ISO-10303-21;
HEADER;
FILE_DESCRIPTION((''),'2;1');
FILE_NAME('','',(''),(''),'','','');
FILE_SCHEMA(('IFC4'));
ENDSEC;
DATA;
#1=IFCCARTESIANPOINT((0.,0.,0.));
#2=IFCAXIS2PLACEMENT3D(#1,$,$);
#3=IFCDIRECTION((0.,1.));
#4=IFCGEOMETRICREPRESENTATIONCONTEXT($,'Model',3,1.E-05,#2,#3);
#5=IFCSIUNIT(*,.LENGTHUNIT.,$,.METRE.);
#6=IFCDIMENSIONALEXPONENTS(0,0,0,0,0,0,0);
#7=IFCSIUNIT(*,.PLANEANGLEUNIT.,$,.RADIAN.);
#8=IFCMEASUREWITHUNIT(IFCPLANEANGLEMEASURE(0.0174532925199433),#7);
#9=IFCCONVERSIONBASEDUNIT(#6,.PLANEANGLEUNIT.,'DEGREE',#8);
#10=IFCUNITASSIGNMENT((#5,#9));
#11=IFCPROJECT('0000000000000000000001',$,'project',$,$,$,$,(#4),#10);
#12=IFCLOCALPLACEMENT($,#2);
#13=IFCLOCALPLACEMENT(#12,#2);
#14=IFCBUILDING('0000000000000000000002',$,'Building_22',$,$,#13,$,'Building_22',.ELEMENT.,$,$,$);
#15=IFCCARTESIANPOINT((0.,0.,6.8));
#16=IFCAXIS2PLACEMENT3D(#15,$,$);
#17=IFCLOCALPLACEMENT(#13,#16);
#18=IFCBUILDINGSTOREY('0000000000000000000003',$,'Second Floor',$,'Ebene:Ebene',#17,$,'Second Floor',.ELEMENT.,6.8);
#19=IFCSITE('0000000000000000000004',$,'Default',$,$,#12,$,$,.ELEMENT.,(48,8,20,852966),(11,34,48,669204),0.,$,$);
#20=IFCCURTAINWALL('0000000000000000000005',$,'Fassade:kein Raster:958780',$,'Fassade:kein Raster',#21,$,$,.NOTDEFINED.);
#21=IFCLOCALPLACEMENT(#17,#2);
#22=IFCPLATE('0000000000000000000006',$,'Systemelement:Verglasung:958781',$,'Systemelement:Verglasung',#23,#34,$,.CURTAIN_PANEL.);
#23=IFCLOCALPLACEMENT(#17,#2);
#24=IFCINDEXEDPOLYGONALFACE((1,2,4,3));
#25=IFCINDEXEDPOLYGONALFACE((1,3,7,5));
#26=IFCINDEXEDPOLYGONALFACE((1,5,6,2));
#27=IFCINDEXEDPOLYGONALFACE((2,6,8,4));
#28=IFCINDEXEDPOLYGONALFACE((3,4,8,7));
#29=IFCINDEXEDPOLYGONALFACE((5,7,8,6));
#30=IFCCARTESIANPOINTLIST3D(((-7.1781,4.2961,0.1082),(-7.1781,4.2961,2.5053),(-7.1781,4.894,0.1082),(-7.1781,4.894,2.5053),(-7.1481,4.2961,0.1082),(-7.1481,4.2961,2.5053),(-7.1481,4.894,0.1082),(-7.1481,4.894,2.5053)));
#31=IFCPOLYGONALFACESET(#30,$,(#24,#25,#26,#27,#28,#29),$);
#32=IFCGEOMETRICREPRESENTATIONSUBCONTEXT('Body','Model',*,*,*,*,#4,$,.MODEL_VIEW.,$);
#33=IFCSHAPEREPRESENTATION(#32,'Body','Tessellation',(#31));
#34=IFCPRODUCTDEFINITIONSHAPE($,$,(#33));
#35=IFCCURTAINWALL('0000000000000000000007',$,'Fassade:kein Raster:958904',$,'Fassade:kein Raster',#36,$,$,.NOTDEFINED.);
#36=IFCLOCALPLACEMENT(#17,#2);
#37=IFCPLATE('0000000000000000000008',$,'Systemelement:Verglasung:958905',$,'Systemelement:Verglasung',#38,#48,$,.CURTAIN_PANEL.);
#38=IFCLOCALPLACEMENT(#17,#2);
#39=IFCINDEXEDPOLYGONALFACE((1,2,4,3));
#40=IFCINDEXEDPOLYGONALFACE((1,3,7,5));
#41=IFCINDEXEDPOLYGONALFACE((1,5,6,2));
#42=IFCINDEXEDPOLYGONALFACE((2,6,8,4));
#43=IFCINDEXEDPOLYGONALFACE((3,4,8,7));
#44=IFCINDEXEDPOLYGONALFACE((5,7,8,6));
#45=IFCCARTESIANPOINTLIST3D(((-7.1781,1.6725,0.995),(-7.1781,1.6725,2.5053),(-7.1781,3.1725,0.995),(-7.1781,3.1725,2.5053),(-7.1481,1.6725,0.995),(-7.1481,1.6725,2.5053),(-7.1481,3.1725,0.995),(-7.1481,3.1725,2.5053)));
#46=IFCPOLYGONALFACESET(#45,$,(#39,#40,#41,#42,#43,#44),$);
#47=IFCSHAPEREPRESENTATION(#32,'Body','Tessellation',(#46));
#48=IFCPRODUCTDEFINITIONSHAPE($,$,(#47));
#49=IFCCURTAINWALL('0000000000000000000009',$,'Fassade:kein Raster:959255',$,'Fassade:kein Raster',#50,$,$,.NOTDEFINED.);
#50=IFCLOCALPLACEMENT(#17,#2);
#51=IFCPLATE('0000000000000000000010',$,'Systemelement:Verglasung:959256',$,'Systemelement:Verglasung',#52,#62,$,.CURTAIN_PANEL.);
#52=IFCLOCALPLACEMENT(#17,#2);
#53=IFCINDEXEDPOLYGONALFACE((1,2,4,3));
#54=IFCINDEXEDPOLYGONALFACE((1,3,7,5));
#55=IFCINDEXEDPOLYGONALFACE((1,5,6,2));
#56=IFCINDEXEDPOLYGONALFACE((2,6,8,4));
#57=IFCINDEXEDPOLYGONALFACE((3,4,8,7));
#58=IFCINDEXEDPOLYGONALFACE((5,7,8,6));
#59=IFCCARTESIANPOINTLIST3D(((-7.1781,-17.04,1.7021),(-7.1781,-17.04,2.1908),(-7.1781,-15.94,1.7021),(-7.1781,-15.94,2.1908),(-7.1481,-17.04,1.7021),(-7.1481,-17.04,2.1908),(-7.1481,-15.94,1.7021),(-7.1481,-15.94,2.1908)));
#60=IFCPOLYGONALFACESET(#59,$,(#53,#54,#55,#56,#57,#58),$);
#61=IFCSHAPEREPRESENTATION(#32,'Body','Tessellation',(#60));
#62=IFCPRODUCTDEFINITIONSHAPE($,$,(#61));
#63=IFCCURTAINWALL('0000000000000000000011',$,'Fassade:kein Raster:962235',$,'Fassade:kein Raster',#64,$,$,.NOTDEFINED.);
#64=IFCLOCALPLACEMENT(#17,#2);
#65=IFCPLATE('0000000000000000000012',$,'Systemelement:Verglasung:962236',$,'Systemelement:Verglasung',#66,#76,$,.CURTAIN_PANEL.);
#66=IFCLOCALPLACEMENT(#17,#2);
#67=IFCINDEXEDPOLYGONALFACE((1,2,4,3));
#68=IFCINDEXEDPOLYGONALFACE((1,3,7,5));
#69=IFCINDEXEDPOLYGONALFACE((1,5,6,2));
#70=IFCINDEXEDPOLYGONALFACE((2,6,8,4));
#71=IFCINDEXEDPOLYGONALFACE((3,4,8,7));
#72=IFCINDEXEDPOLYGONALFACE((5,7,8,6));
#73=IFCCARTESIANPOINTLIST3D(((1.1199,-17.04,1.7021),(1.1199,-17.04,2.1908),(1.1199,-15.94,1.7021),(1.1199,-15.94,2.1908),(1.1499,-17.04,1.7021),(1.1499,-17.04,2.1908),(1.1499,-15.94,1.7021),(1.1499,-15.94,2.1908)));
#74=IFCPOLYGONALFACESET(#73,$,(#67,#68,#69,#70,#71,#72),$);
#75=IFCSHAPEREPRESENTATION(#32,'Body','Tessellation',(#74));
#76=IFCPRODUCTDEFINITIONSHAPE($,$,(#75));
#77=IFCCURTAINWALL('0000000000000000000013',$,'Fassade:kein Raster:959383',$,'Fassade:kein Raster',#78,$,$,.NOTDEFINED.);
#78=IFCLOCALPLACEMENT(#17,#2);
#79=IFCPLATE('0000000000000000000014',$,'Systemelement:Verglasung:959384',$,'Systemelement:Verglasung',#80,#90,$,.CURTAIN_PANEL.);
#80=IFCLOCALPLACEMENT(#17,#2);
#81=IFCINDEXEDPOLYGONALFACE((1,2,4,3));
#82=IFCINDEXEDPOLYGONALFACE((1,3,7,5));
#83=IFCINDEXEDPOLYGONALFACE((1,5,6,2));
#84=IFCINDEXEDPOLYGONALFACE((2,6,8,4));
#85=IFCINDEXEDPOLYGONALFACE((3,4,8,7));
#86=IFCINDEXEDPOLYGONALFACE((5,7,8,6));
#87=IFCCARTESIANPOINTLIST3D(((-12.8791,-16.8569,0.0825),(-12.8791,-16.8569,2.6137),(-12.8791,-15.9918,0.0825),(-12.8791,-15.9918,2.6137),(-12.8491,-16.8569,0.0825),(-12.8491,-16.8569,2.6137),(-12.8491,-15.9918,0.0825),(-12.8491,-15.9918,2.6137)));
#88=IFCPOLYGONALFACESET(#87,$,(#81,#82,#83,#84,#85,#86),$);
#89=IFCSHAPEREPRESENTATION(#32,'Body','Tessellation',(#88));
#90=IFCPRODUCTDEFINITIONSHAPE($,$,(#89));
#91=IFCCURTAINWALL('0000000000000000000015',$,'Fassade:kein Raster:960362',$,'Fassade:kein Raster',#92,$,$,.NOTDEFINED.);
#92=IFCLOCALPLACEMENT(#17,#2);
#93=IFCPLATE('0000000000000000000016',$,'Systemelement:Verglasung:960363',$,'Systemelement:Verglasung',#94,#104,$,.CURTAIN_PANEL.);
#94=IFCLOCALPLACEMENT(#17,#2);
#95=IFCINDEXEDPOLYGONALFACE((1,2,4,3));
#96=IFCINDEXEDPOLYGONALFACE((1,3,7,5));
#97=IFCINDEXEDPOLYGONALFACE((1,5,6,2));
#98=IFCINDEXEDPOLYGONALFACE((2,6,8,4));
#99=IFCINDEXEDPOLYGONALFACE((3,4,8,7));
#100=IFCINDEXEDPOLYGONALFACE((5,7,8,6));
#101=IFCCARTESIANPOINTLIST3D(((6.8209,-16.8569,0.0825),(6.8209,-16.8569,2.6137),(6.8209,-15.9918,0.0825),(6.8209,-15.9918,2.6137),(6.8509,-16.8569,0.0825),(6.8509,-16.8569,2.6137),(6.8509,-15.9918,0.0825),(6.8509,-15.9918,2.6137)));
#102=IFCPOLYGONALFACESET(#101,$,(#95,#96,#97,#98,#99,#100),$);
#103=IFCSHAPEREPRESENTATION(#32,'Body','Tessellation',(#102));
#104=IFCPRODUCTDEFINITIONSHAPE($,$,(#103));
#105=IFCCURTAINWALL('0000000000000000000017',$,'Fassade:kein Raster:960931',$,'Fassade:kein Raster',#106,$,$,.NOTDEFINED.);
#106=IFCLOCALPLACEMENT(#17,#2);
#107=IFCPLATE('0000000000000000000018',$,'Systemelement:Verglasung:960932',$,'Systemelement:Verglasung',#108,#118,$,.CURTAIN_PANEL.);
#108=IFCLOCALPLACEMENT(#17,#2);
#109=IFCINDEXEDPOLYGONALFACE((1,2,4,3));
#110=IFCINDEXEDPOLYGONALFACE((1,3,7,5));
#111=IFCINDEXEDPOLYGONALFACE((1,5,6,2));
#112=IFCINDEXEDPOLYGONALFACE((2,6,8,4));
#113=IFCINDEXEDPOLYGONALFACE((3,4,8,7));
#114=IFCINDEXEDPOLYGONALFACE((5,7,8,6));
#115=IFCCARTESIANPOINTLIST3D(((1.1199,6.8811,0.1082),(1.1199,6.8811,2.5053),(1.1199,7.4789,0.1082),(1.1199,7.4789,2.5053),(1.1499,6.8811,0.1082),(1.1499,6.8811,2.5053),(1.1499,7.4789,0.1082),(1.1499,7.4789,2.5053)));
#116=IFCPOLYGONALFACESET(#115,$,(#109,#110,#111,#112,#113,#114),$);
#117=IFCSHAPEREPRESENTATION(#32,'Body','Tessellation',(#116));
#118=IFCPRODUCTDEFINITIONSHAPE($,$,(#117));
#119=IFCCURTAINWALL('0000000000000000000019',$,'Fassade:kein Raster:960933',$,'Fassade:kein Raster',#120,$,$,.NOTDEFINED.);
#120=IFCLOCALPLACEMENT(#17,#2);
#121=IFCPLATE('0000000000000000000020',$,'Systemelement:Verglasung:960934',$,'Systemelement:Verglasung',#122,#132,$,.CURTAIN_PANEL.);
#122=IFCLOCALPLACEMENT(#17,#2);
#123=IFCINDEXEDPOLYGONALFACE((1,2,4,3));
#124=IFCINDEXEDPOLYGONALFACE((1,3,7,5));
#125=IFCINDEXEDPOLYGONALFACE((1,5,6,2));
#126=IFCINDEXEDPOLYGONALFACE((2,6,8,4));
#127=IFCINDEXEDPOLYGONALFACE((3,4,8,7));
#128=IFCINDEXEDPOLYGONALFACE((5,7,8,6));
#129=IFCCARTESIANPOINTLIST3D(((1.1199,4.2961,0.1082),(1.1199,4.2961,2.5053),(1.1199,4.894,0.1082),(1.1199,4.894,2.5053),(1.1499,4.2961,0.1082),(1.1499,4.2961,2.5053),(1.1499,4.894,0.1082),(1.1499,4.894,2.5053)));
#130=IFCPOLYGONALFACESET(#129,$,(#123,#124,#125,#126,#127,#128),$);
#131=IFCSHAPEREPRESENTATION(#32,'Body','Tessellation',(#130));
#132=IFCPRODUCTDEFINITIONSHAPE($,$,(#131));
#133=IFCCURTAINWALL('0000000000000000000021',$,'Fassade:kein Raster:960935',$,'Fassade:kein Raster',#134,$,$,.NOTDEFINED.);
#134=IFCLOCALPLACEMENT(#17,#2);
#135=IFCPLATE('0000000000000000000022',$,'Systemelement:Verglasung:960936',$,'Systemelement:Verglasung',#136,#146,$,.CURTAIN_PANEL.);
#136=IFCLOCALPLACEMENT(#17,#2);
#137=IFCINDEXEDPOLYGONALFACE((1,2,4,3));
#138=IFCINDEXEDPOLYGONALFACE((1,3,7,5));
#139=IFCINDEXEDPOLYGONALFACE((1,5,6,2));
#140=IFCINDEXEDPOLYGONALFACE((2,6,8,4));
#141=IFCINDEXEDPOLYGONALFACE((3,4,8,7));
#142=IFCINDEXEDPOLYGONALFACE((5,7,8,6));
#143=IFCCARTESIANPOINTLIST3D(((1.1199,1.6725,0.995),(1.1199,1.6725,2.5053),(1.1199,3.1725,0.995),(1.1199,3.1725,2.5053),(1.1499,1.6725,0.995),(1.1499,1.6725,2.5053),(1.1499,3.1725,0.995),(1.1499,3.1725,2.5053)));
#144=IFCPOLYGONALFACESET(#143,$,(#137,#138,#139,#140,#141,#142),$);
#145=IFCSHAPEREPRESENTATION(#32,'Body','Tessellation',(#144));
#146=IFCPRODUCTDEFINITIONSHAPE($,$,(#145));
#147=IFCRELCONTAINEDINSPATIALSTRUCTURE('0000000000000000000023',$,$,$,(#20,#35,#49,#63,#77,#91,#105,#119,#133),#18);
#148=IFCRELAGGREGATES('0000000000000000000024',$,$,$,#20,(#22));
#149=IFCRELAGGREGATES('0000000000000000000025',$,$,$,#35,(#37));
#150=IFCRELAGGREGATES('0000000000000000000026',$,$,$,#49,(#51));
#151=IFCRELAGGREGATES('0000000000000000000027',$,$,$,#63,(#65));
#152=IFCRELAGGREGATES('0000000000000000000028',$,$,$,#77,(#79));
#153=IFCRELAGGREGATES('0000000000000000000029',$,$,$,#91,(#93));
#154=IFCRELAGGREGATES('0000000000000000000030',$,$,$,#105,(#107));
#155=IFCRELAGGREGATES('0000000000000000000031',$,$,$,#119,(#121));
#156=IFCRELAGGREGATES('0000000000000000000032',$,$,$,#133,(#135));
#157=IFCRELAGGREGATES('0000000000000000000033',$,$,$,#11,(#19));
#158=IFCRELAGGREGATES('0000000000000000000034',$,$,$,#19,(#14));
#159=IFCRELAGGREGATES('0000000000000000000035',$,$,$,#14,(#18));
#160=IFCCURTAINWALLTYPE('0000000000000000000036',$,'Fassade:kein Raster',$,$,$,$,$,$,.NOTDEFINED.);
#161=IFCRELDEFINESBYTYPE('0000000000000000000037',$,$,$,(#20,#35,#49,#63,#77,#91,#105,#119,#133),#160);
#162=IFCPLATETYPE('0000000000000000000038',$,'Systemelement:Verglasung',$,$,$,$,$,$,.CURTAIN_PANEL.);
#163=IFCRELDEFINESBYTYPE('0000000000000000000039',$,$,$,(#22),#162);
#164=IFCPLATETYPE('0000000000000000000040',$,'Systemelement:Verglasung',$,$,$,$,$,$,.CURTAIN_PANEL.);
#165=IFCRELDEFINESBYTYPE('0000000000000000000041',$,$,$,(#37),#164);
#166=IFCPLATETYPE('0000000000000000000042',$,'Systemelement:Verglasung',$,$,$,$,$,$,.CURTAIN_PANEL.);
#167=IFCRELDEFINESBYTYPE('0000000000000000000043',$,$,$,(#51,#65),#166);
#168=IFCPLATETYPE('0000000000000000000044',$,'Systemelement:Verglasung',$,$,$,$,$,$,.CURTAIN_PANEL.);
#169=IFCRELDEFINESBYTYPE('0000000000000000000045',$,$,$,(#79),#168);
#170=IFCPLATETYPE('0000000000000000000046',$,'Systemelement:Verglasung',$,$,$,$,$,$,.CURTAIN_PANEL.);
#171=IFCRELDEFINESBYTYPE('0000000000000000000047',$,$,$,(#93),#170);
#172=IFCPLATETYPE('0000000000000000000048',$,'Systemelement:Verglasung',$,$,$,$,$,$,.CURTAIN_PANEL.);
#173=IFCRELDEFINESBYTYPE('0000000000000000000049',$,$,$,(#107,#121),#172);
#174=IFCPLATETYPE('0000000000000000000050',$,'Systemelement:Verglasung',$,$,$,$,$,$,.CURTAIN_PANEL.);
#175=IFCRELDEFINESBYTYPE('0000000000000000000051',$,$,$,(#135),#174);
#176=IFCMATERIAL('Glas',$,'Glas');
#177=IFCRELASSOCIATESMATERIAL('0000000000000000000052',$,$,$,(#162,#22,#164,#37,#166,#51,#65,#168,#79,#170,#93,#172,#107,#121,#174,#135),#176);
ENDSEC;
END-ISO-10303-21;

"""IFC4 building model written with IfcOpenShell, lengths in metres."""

from ifc_helpers import new_model, entity, si_unit, converted_unit, direction, frame, origin, place, context, subcontext, project, spatial, indexed_curve, outline, extrude, source, transform, mapped, material, type_object, type_shapes, element, aggregate, save


model = new_model("IFC4")

# Units and contexts
model_context = context("Model", 3, precision=1e-05, world=origin(), true_north=direction((0.0, 1.0)))
body_context = subcontext(model_context, "Body", "Model", "MODEL_VIEW")
ifc_project = project(units=[si_unit("LENGTHUNIT", "METRE"), converted_unit("PLANEANGLEUNIT", "DEGREE", entity("IfcPlaneAngleMeasure", 0.0174532925199433), si_unit("PLANEANGLEUNIT", "RADIAN"), dimensions=[0, 0, 0, 0, 0, 0, 0])], contexts=[model_context])

# Site, building, storey
site_placement = place(None, origin())
site = spatial("IfcSite", under=ifc_project, at=site_placement, Name="Default", CompositionType="ELEMENT", RefLatitude=(48, 8, 20, 852966), RefLongitude=(11, 34, 48, 669204), RefElevation=0.0)
building_placement = place(site_placement, origin())
building = spatial("IfcBuilding", under=site, at=building_placement, Name="Building_22", LongName="Building_22", CompositionType="ELEMENT")
storey_placement = place(building_placement, frame((0.0, 0.0, 6.8)))
storey = spatial("IfcBuildingStorey", under=building, at=storey_placement, Name="Second Floor", ObjectType="Ebene:Ebene", LongName="Second Floor", CompositionType="ELEMENT", Elevation=6.8)

# Curtain walls, plates
curtain_wall_type_1 = type_object("IfcCurtainWallType", Name="Fassade:kein Raster", PredefinedType="NOTDEFINED")
ifc_material_1 = material(Name="Glas", Category="Glas")
plate_type_1 = type_object("IfcPlateType", Name="Systemelement:Verglasung", PredefinedType="CURTAIN_PANEL", material=ifc_material_1)
shared_shape_1 = source(origin(), body_context, "Body", "SweptSolid", [
    extrude(outline(indexed_curve([(-0.015, -0.2989), (0.015, -0.2989), (0.015, 0.2989), (-0.015, 0.2989), (-0.015, -0.2989)], self_intersect=False)), frame((0.0, 0.0, 0.0), z_axis=(0.0, 0.0, 1.0), x_axis=(0.0, 1.0, 0.0)), (0.0, 0.0, 1.0), 2.3972),
])
type_shapes(plate_type_1, [shared_shape_1])
curtain_wall_1_placement = place(storey_placement, frame((0.0, 0.0, -6.8)))
curtain_wall_1 = element("IfcCurtainWall", 1, at=curtain_wall_1_placement, inside=storey, type_object=curtain_wall_type_1, Name="Fassade:kein Raster:958780", ObjectType="Fassade:kein Raster", PredefinedType="NOTDEFINED")
plate_1_placement = place(curtain_wall_1_placement, frame((-7.1631, 4.595, 6.9082), z_axis=(0.0, 0.0, 1.0), x_axis=(0.0, -1.0, 0.0)))
plate_1 = element("IfcPlate", 2, at=plate_1_placement, type_object=plate_type_1, material=ifc_material_1, Name="Systemelement:Verglasung:958781", ObjectType="Systemelement:Verglasung", PredefinedType="CURTAIN_PANEL", context=body_context, shape_type="MappedRepresentation", body=[
    mapped(shared_shape_1, transform((0.0, 0.0, 0.0), scale=1.0)),
])
aggregate(curtain_wall_1, [plate_1])
curtain_wall_2_placement = place(storey_placement, frame((0.0, 0.0, -6.8)))
curtain_wall_2 = element("IfcCurtainWall", 3, at=curtain_wall_2_placement, inside=storey, type_object=curtain_wall_type_1, Name="Fassade:kein Raster:958904", ObjectType="Fassade:kein Raster", PredefinedType="NOTDEFINED")
plate_type_2 = type_object("IfcPlateType", Name="Systemelement:Verglasung", PredefinedType="CURTAIN_PANEL", material=ifc_material_1)
shared_shape_2 = source(origin(), body_context, "Body", "SweptSolid", [
    extrude(outline(indexed_curve([(-0.015, -0.75), (0.015, -0.75), (0.015, 0.75), (-0.015, 0.75), (-0.015, -0.75)], self_intersect=False)), frame((0.0, 0.0, 0.0), z_axis=(0.0, 0.0, 1.0), x_axis=(0.0, 1.0, 0.0)), (0.0, 0.0, 1.0), 1.5104),
])
type_shapes(plate_type_2, [shared_shape_2])
plate_2_placement = place(curtain_wall_2_placement, frame((-7.1631, 2.4225, 7.795), z_axis=(0.0, 0.0, 1.0), x_axis=(0.0, -1.0, 0.0)))
plate_2 = element("IfcPlate", 4, at=plate_2_placement, type_object=plate_type_2, material=ifc_material_1, Name="Systemelement:Verglasung:958905", ObjectType="Systemelement:Verglasung", PredefinedType="CURTAIN_PANEL", context=body_context, shape_type="MappedRepresentation", body=[
    mapped(shared_shape_2, transform((0.0, 0.0, 0.0), scale=1.0)),
])
aggregate(curtain_wall_2, [plate_2])
curtain_wall_3_placement = place(storey_placement, frame((0.0, 0.0, -6.8)))
curtain_wall_3 = element("IfcCurtainWall", 5, at=curtain_wall_3_placement, inside=storey, type_object=curtain_wall_type_1, Name="Fassade:kein Raster:959255", ObjectType="Fassade:kein Raster", PredefinedType="NOTDEFINED")
plate_type_3 = type_object("IfcPlateType", Name="Systemelement:Verglasung", PredefinedType="CURTAIN_PANEL", material=ifc_material_1)
shared_shape_3 = source(origin(), body_context, "Body", "SweptSolid", [
    extrude(outline(indexed_curve([(-0.015, -0.55), (0.015, -0.55), (0.015, 0.55), (-0.015, 0.55), (-0.015, -0.55)], self_intersect=False)), frame((0.0, 0.0, 0.0), z_axis=(0.0, 0.0, 1.0), x_axis=(0.0, 1.0, 0.0)), (0.0, 0.0, 1.0), 0.4887),
])
type_shapes(plate_type_3, [shared_shape_3])
plate_3_placement = place(curtain_wall_3_placement, frame((-7.1631, -16.49, 8.5021), z_axis=(0.0, 0.0, 1.0), x_axis=(0.0, -1.0, 0.0)))
plate_3 = element("IfcPlate", 6, at=plate_3_placement, type_object=plate_type_3, material=ifc_material_1, Name="Systemelement:Verglasung:959256", ObjectType="Systemelement:Verglasung", PredefinedType="CURTAIN_PANEL", context=body_context, shape_type="MappedRepresentation", body=[
    mapped(shared_shape_3, transform((0.0, 0.0, 0.0), scale=1.0)),
])
aggregate(curtain_wall_3, [plate_3])
curtain_wall_4_placement = place(storey_placement, frame((0.0, 0.0, -6.8)))
curtain_wall_4 = element("IfcCurtainWall", 7, at=curtain_wall_4_placement, inside=storey, type_object=curtain_wall_type_1, Name="Fassade:kein Raster:962235", ObjectType="Fassade:kein Raster", PredefinedType="NOTDEFINED")
plate_4_placement = place(curtain_wall_4_placement, frame((1.1349, -16.49, 8.5021), z_axis=(0.0, 0.0, 1.0), x_axis=(0.0, -1.0, 0.0)))
plate_4 = element("IfcPlate", 8, at=plate_4_placement, type_object=plate_type_3, material=ifc_material_1, Name="Systemelement:Verglasung:962236", ObjectType="Systemelement:Verglasung", PredefinedType="CURTAIN_PANEL", context=body_context, shape_type="MappedRepresentation", body=[
    mapped(shared_shape_3, transform((0.0, 0.0, 0.0), scale=1.0)),
])
aggregate(curtain_wall_4, [plate_4])
curtain_wall_5_placement = place(storey_placement, frame((0.0, 0.0, -6.8)))
curtain_wall_5 = element("IfcCurtainWall", 9, at=curtain_wall_5_placement, inside=storey, type_object=curtain_wall_type_1, Name="Fassade:kein Raster:959383", ObjectType="Fassade:kein Raster", PredefinedType="NOTDEFINED")
plate_type_4 = type_object("IfcPlateType", Name="Systemelement:Verglasung", PredefinedType="CURTAIN_PANEL", material=ifc_material_1)
shared_shape_4 = source(origin(), body_context, "Body", "SweptSolid", [
    extrude(outline(indexed_curve([(-0.015, -0.4325), (0.015, -0.4325), (0.015, 0.4325), (-0.015, 0.4325), (-0.015, -0.4325)], self_intersect=False)), frame((0.0, 0.0, 0.0), z_axis=(0.0, 0.0, 1.0), x_axis=(0.0, 1.0, 0.0)), (0.0, 0.0, 1.0), 2.5312),
])
type_shapes(plate_type_4, [shared_shape_4])
plate_5_placement = place(curtain_wall_5_placement, frame((-12.8641, -16.4243, 6.8825), z_axis=(0.0, 0.0, 1.0), x_axis=(0.0, -1.0, 0.0)))
plate_5 = element("IfcPlate", 10, at=plate_5_placement, type_object=plate_type_4, material=ifc_material_1, Name="Systemelement:Verglasung:959384", ObjectType="Systemelement:Verglasung", PredefinedType="CURTAIN_PANEL", context=body_context, shape_type="MappedRepresentation", body=[
    mapped(shared_shape_4, transform((0.0, 0.0, 0.0), scale=1.0)),
])
aggregate(curtain_wall_5, [plate_5])
curtain_wall_6_placement = place(storey_placement, frame((0.0, 0.0, -6.8)))
curtain_wall_6 = element("IfcCurtainWall", 11, at=curtain_wall_6_placement, inside=storey, type_object=curtain_wall_type_1, Name="Fassade:kein Raster:960362", ObjectType="Fassade:kein Raster", PredefinedType="NOTDEFINED")
plate_type_5 = type_object("IfcPlateType", Name="Systemelement:Verglasung", PredefinedType="CURTAIN_PANEL", material=ifc_material_1)
shared_shape_5 = source(origin(), body_context, "Body", "SweptSolid", [
    extrude(outline(indexed_curve([(-0.015, -0.4325), (0.015, -0.4325), (0.015, 0.4325), (-0.015, 0.4325), (-0.015, -0.4325)], self_intersect=False)), frame((0.0, 0.0, 0.0), z_axis=(0.0, 0.0, 1.0), x_axis=(0.0, 1.0, 0.0)), (0.0, 0.0, 1.0), 2.5312),
])
type_shapes(plate_type_5, [shared_shape_5])
plate_6_placement = place(curtain_wall_6_placement, frame((6.8359, -16.4243, 6.8825), z_axis=(0.0, 0.0, 1.0), x_axis=(0.0, -1.0, 0.0)))
plate_6 = element("IfcPlate", 12, at=plate_6_placement, type_object=plate_type_5, material=ifc_material_1, Name="Systemelement:Verglasung:960363", ObjectType="Systemelement:Verglasung", PredefinedType="CURTAIN_PANEL", context=body_context, shape_type="MappedRepresentation", body=[
    mapped(shared_shape_5, transform((0.0, 0.0, 0.0), scale=1.0)),
])
aggregate(curtain_wall_6, [plate_6])
curtain_wall_7_placement = place(storey_placement, frame((0.0, 0.0, -6.8)))
curtain_wall_7 = element("IfcCurtainWall", 13, at=curtain_wall_7_placement, inside=storey, type_object=curtain_wall_type_1, Name="Fassade:kein Raster:960931", ObjectType="Fassade:kein Raster", PredefinedType="NOTDEFINED")
plate_type_6 = type_object("IfcPlateType", Name="Systemelement:Verglasung", PredefinedType="CURTAIN_PANEL", material=ifc_material_1)
shared_shape_6 = source(origin(), body_context, "Body", "SweptSolid", [
    extrude(outline(indexed_curve([(-0.015, -0.2989), (0.015, -0.2989), (0.015, 0.2989), (-0.015, 0.2989), (-0.015, -0.2989)], self_intersect=False)), frame((0.0, 0.0, 0.0), z_axis=(0.0, 0.0, 1.0), x_axis=(0.0, 1.0, 0.0)), (0.0, 0.0, 1.0), 2.3972),
])
type_shapes(plate_type_6, [shared_shape_6])
plate_7_placement = place(curtain_wall_7_placement, frame((1.1349, 7.18, 6.9082), z_axis=(0.0, 0.0, 1.0), x_axis=(0.0, -1.0, 0.0)))
plate_7 = element("IfcPlate", 14, at=plate_7_placement, type_object=plate_type_6, material=ifc_material_1, Name="Systemelement:Verglasung:960932", ObjectType="Systemelement:Verglasung", PredefinedType="CURTAIN_PANEL", context=body_context, shape_type="MappedRepresentation", body=[
    mapped(shared_shape_6, transform((0.0, 0.0, 0.0), scale=1.0)),
])
aggregate(curtain_wall_7, [plate_7])
curtain_wall_8_placement = place(storey_placement, frame((0.0, 0.0, -6.8)))
curtain_wall_8 = element("IfcCurtainWall", 15, at=curtain_wall_8_placement, inside=storey, type_object=curtain_wall_type_1, Name="Fassade:kein Raster:960933", ObjectType="Fassade:kein Raster", PredefinedType="NOTDEFINED")
plate_8_placement = place(curtain_wall_8_placement, frame((1.1349, 4.595, 6.9082), z_axis=(0.0, 0.0, 1.0), x_axis=(0.0, -1.0, 0.0)))
plate_8 = element("IfcPlate", 16, at=plate_8_placement, type_object=plate_type_6, material=ifc_material_1, Name="Systemelement:Verglasung:960934", ObjectType="Systemelement:Verglasung", PredefinedType="CURTAIN_PANEL", context=body_context, shape_type="MappedRepresentation", body=[
    mapped(shared_shape_6, transform((0.0, 0.0, 0.0), scale=1.0)),
])
aggregate(curtain_wall_8, [plate_8])
curtain_wall_9_placement = place(storey_placement, frame((0.0, 0.0, -6.8)))
curtain_wall_9 = element("IfcCurtainWall", 17, at=curtain_wall_9_placement, inside=storey, type_object=curtain_wall_type_1, Name="Fassade:kein Raster:960935", ObjectType="Fassade:kein Raster", PredefinedType="NOTDEFINED")
plate_type_7 = type_object("IfcPlateType", Name="Systemelement:Verglasung", PredefinedType="CURTAIN_PANEL", material=ifc_material_1)
shared_shape_7 = source(origin(), body_context, "Body", "SweptSolid", [
    extrude(outline(indexed_curve([(-0.015, -0.75), (0.015, -0.75), (0.015, 0.75), (-0.015, 0.75), (-0.015, -0.75)], self_intersect=False)), frame((0.0, 0.0, 0.0), z_axis=(0.0, 0.0, 1.0), x_axis=(0.0, 1.0, 0.0)), (0.0, 0.0, 1.0), 1.5104),
])
type_shapes(plate_type_7, [shared_shape_7])
plate_9_placement = place(curtain_wall_9_placement, frame((1.1349, 2.4225, 7.795), z_axis=(0.0, 0.0, 1.0), x_axis=(0.0, -1.0, 0.0)))
plate_9 = element("IfcPlate", 18, at=plate_9_placement, type_object=plate_type_7, material=ifc_material_1, Name="Systemelement:Verglasung:960936", ObjectType="Systemelement:Verglasung", PredefinedType="CURTAIN_PANEL", context=body_context, shape_type="MappedRepresentation", body=[
    mapped(shared_shape_7, transform((0.0, 0.0, 0.0), scale=1.0)),
])
aggregate(curtain_wall_9, [plate_9])

save(model, "model.ifc")
